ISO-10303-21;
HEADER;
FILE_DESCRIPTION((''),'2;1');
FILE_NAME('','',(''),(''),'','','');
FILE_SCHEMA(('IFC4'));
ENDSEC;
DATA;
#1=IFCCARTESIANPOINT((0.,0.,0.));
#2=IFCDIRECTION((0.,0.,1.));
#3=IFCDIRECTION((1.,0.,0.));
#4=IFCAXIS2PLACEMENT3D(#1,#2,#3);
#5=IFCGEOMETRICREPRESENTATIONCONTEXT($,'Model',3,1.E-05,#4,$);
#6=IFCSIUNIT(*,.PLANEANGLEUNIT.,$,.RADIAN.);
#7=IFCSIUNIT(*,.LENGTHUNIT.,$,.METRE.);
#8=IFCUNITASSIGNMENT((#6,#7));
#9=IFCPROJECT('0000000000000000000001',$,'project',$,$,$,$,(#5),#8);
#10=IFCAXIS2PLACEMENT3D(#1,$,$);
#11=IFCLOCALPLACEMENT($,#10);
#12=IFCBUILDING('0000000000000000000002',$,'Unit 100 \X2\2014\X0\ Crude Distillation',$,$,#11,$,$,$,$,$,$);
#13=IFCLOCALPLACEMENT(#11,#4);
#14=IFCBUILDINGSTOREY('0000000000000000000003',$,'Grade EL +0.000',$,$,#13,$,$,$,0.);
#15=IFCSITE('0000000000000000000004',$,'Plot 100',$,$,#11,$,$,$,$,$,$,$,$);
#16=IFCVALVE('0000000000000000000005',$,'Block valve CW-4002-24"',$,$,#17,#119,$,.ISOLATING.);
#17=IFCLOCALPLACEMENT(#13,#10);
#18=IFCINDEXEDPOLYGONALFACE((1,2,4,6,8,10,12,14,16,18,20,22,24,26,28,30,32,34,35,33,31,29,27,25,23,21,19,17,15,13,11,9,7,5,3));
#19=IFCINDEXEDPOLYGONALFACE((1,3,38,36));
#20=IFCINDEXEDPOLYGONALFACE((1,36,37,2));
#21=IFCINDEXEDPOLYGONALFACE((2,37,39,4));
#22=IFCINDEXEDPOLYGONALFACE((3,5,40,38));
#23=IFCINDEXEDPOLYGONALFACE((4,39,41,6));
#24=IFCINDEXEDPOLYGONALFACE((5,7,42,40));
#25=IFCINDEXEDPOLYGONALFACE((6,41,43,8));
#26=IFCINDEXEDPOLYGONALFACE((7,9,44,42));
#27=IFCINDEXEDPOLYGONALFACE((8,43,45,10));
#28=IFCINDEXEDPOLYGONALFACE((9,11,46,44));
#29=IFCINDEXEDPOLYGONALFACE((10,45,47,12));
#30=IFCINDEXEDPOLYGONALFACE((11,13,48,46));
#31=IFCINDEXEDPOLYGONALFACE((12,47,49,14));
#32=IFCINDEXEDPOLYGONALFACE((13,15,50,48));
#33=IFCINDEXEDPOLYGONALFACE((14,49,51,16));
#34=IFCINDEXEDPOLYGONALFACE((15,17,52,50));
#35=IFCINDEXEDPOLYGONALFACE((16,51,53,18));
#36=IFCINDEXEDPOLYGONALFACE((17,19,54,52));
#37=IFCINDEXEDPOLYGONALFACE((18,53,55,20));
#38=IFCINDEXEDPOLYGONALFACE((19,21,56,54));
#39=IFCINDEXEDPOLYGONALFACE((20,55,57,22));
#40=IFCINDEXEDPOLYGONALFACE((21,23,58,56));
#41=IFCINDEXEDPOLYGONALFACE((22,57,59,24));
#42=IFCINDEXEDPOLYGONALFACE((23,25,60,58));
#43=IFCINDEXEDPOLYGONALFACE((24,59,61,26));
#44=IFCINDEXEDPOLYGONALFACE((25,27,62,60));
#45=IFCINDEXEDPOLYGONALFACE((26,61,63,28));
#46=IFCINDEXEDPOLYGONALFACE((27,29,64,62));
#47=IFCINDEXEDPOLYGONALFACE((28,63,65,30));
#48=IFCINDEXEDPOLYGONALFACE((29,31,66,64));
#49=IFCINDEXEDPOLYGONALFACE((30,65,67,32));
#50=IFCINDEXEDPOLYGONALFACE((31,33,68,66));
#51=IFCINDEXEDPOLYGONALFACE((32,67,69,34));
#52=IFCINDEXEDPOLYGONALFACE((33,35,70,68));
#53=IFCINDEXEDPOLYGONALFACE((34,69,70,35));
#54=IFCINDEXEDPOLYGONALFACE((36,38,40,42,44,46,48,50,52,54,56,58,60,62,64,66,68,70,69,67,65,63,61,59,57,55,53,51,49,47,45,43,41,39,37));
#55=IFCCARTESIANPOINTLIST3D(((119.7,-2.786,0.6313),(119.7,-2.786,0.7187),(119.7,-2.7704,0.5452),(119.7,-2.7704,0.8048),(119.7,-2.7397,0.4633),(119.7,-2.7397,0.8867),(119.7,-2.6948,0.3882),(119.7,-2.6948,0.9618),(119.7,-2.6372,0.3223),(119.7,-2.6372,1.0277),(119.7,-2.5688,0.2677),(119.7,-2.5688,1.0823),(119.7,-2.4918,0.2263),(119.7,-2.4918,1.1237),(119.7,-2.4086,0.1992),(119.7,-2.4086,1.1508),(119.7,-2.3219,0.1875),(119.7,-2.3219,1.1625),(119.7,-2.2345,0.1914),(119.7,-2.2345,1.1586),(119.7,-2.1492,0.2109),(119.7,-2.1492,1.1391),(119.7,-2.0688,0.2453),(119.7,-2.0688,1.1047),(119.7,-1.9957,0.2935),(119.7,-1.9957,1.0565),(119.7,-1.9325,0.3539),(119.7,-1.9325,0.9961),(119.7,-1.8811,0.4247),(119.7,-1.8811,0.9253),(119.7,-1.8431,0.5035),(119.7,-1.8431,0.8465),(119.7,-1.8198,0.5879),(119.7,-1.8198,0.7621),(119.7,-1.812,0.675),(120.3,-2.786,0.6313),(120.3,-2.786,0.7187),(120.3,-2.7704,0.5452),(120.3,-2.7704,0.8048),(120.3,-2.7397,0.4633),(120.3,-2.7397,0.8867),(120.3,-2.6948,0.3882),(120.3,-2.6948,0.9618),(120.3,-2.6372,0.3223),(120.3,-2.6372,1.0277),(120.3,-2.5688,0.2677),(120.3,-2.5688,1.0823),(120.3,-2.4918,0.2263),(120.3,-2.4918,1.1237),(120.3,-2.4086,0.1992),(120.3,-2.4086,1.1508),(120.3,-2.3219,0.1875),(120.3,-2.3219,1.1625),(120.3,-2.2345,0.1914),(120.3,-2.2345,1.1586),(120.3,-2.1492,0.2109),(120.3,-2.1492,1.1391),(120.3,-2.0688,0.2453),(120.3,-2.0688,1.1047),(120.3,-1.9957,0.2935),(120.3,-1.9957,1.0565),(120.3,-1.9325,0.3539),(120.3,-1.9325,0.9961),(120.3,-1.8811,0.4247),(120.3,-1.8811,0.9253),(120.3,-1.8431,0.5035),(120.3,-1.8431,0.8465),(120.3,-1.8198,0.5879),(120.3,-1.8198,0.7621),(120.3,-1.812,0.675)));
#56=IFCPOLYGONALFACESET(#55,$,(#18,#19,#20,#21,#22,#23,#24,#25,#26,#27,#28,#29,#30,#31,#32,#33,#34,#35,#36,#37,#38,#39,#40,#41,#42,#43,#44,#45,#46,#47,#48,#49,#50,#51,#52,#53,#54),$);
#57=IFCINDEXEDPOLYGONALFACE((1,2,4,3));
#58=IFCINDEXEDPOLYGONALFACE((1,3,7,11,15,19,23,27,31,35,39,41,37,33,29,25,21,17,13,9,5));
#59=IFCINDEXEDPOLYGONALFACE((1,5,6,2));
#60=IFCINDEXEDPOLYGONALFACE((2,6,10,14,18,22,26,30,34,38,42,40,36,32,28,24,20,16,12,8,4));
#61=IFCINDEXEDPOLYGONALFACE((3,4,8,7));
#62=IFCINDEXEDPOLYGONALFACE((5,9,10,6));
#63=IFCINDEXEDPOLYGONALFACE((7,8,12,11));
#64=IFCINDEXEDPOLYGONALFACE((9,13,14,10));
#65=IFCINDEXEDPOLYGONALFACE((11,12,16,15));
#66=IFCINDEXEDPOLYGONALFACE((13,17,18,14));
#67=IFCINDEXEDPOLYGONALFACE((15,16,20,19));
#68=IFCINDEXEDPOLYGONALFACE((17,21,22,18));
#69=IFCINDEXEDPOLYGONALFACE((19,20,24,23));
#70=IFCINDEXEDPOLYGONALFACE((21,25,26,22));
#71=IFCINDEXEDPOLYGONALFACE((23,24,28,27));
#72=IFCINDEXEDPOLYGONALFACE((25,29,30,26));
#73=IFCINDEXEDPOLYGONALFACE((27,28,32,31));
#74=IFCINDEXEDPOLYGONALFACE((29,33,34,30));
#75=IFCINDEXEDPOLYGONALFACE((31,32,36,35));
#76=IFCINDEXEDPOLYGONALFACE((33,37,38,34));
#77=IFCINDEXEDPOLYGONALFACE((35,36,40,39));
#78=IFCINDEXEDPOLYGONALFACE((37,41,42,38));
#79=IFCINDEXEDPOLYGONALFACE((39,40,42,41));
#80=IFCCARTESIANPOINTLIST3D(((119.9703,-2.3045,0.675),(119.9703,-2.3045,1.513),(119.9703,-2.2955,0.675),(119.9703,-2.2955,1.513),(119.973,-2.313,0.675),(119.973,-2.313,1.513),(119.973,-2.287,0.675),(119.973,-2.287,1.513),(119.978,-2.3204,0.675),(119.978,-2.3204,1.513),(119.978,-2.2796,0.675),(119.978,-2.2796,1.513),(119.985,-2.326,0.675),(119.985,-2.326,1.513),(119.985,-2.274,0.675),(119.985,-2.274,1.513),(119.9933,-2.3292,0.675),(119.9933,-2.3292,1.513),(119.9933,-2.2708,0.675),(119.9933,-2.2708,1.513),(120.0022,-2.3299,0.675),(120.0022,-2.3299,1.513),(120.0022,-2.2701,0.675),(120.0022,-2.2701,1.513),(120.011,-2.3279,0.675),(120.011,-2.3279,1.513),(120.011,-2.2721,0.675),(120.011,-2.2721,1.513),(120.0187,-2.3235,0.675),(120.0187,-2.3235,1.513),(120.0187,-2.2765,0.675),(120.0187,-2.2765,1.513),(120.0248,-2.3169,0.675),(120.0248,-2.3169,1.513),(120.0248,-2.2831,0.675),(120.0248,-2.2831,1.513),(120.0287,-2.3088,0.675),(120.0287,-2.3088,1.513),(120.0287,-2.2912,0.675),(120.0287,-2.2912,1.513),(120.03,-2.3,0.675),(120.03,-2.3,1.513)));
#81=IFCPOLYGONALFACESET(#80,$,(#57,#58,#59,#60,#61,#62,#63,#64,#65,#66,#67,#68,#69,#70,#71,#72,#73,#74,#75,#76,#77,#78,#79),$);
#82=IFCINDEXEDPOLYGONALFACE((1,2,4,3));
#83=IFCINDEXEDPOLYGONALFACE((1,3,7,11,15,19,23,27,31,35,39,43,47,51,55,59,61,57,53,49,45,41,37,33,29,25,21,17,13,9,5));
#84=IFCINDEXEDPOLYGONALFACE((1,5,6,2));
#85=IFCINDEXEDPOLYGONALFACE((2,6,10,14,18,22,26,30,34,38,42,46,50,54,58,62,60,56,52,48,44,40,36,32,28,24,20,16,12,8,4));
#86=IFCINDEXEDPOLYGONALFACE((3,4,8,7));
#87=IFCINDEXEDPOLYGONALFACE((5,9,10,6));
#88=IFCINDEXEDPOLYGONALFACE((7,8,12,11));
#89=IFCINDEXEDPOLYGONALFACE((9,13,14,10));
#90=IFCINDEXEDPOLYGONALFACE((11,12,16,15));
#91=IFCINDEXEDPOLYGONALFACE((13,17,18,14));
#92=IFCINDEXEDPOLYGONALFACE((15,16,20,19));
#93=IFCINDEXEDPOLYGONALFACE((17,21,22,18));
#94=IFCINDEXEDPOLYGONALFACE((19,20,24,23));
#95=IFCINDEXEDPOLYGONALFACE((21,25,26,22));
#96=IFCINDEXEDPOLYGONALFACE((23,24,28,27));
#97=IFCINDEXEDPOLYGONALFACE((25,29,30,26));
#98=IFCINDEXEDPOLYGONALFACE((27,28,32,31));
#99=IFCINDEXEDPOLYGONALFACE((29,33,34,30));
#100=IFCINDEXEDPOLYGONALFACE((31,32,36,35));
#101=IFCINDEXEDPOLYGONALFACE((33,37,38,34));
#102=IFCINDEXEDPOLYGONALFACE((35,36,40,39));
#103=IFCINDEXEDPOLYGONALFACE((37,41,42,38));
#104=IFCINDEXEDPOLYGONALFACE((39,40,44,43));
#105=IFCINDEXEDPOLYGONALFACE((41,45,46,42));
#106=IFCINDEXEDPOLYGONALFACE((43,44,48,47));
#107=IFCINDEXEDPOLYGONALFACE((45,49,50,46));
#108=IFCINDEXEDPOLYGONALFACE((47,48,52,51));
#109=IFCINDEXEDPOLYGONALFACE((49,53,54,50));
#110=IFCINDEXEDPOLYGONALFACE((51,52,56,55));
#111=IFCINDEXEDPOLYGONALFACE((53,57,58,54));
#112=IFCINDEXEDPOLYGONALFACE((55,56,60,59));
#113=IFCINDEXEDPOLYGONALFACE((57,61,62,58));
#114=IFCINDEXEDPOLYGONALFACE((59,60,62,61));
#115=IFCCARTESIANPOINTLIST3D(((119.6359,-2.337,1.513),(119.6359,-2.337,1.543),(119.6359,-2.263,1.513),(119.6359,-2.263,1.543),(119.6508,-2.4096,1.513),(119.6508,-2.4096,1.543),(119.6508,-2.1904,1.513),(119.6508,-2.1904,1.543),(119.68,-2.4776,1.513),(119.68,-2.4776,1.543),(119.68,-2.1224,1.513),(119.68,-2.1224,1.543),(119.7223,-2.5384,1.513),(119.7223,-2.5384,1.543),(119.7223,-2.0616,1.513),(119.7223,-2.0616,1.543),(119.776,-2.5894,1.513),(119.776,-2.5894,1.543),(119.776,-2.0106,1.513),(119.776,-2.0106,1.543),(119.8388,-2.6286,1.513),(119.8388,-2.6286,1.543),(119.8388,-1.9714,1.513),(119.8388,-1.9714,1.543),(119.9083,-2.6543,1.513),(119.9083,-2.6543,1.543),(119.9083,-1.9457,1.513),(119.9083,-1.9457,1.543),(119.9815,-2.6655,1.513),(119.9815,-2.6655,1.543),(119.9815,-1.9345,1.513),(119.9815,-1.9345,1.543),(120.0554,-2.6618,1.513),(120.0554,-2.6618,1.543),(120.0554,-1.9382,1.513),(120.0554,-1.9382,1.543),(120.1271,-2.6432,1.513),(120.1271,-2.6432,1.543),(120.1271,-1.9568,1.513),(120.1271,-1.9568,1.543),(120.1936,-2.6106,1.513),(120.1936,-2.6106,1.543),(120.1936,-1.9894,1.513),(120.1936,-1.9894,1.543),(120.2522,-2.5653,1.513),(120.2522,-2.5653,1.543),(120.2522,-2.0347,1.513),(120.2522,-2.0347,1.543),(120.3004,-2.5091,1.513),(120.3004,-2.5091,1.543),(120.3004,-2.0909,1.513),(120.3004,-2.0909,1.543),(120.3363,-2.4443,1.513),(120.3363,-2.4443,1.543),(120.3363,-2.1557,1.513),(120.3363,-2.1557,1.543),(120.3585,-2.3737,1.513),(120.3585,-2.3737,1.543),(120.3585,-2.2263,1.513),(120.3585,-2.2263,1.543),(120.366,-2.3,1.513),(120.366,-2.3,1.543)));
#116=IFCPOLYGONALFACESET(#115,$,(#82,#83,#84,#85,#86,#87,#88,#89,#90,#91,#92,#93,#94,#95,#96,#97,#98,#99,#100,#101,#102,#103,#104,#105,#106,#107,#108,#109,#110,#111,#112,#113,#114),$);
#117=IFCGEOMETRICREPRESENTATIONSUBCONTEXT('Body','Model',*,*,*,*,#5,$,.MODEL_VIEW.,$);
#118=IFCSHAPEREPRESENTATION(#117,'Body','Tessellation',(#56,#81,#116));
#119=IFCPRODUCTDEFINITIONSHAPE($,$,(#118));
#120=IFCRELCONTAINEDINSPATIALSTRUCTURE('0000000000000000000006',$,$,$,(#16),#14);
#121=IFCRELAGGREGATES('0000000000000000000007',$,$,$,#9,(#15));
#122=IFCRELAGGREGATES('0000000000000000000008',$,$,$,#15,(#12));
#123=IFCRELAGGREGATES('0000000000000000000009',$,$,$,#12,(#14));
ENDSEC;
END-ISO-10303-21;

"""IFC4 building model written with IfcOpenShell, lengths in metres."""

from ifc_helpers import new_model, si_unit, frame, origin, origin_with_axes, origin_2d, place, context, subcontext, project, spatial, circle, extrude, element, save


model = new_model("IFC4")

# Units and contexts
model_context = context("Model", 3, precision=1e-05, world=origin_with_axes())
body_context = subcontext(model_context, "Body", "Model", "MODEL_VIEW")
ifc_project = project(units=[si_unit("PLANEANGLEUNIT", "RADIAN"), si_unit("LENGTHUNIT", "METRE")], contexts=[model_context])

# Site, building, storey
placement = place(None, origin())
site = spatial("IfcSite", under=ifc_project, at=placement, Name="Plot 100")
building = spatial("IfcBuilding", under=site, at=placement, Name="Unit 100 — Crude Distillation")
storey_placement = place(placement, origin_with_axes())
storey = spatial("IfcBuildingStorey", under=building, at=storey_placement, Name="Grade EL +0.000", Elevation=0.0)

# Valve
valve_1_placement = place(storey_placement, origin_with_axes())
element("IfcValve", 1, at=valve_1_placement, inside=storey, Name="Block valve CW-4002-24\"", PredefinedType="ISOLATING", context=body_context, shape_type="SweptSolid", body=[
    extrude(circle(Radius=0.488, at=origin_2d()), frame((119.7, -2.3, 0.675), z_axis=(1.0, 0.0, 0.0), x_axis=(0.0, 1.0, 0.0)), (0.0, 0.0, 1.0), 0.6),
    extrude(circle(Radius=0.03, at=origin_2d()), frame((120.0, -2.3, 0.675), z_axis=(0.0, 0.0, 1.0), x_axis=(1.0, 0.0, 0.0)), (0.0, 0.0, 1.0), 0.838),
    extrude(circle(Radius=0.366, at=origin_2d()), frame((120.0, -2.3, 1.513), z_axis=(0.0, 0.0, 1.0), x_axis=(1.0, 0.0, 0.0)), (0.0, 0.0, 1.0), 0.03),
])

save(model, "model.ifc")
